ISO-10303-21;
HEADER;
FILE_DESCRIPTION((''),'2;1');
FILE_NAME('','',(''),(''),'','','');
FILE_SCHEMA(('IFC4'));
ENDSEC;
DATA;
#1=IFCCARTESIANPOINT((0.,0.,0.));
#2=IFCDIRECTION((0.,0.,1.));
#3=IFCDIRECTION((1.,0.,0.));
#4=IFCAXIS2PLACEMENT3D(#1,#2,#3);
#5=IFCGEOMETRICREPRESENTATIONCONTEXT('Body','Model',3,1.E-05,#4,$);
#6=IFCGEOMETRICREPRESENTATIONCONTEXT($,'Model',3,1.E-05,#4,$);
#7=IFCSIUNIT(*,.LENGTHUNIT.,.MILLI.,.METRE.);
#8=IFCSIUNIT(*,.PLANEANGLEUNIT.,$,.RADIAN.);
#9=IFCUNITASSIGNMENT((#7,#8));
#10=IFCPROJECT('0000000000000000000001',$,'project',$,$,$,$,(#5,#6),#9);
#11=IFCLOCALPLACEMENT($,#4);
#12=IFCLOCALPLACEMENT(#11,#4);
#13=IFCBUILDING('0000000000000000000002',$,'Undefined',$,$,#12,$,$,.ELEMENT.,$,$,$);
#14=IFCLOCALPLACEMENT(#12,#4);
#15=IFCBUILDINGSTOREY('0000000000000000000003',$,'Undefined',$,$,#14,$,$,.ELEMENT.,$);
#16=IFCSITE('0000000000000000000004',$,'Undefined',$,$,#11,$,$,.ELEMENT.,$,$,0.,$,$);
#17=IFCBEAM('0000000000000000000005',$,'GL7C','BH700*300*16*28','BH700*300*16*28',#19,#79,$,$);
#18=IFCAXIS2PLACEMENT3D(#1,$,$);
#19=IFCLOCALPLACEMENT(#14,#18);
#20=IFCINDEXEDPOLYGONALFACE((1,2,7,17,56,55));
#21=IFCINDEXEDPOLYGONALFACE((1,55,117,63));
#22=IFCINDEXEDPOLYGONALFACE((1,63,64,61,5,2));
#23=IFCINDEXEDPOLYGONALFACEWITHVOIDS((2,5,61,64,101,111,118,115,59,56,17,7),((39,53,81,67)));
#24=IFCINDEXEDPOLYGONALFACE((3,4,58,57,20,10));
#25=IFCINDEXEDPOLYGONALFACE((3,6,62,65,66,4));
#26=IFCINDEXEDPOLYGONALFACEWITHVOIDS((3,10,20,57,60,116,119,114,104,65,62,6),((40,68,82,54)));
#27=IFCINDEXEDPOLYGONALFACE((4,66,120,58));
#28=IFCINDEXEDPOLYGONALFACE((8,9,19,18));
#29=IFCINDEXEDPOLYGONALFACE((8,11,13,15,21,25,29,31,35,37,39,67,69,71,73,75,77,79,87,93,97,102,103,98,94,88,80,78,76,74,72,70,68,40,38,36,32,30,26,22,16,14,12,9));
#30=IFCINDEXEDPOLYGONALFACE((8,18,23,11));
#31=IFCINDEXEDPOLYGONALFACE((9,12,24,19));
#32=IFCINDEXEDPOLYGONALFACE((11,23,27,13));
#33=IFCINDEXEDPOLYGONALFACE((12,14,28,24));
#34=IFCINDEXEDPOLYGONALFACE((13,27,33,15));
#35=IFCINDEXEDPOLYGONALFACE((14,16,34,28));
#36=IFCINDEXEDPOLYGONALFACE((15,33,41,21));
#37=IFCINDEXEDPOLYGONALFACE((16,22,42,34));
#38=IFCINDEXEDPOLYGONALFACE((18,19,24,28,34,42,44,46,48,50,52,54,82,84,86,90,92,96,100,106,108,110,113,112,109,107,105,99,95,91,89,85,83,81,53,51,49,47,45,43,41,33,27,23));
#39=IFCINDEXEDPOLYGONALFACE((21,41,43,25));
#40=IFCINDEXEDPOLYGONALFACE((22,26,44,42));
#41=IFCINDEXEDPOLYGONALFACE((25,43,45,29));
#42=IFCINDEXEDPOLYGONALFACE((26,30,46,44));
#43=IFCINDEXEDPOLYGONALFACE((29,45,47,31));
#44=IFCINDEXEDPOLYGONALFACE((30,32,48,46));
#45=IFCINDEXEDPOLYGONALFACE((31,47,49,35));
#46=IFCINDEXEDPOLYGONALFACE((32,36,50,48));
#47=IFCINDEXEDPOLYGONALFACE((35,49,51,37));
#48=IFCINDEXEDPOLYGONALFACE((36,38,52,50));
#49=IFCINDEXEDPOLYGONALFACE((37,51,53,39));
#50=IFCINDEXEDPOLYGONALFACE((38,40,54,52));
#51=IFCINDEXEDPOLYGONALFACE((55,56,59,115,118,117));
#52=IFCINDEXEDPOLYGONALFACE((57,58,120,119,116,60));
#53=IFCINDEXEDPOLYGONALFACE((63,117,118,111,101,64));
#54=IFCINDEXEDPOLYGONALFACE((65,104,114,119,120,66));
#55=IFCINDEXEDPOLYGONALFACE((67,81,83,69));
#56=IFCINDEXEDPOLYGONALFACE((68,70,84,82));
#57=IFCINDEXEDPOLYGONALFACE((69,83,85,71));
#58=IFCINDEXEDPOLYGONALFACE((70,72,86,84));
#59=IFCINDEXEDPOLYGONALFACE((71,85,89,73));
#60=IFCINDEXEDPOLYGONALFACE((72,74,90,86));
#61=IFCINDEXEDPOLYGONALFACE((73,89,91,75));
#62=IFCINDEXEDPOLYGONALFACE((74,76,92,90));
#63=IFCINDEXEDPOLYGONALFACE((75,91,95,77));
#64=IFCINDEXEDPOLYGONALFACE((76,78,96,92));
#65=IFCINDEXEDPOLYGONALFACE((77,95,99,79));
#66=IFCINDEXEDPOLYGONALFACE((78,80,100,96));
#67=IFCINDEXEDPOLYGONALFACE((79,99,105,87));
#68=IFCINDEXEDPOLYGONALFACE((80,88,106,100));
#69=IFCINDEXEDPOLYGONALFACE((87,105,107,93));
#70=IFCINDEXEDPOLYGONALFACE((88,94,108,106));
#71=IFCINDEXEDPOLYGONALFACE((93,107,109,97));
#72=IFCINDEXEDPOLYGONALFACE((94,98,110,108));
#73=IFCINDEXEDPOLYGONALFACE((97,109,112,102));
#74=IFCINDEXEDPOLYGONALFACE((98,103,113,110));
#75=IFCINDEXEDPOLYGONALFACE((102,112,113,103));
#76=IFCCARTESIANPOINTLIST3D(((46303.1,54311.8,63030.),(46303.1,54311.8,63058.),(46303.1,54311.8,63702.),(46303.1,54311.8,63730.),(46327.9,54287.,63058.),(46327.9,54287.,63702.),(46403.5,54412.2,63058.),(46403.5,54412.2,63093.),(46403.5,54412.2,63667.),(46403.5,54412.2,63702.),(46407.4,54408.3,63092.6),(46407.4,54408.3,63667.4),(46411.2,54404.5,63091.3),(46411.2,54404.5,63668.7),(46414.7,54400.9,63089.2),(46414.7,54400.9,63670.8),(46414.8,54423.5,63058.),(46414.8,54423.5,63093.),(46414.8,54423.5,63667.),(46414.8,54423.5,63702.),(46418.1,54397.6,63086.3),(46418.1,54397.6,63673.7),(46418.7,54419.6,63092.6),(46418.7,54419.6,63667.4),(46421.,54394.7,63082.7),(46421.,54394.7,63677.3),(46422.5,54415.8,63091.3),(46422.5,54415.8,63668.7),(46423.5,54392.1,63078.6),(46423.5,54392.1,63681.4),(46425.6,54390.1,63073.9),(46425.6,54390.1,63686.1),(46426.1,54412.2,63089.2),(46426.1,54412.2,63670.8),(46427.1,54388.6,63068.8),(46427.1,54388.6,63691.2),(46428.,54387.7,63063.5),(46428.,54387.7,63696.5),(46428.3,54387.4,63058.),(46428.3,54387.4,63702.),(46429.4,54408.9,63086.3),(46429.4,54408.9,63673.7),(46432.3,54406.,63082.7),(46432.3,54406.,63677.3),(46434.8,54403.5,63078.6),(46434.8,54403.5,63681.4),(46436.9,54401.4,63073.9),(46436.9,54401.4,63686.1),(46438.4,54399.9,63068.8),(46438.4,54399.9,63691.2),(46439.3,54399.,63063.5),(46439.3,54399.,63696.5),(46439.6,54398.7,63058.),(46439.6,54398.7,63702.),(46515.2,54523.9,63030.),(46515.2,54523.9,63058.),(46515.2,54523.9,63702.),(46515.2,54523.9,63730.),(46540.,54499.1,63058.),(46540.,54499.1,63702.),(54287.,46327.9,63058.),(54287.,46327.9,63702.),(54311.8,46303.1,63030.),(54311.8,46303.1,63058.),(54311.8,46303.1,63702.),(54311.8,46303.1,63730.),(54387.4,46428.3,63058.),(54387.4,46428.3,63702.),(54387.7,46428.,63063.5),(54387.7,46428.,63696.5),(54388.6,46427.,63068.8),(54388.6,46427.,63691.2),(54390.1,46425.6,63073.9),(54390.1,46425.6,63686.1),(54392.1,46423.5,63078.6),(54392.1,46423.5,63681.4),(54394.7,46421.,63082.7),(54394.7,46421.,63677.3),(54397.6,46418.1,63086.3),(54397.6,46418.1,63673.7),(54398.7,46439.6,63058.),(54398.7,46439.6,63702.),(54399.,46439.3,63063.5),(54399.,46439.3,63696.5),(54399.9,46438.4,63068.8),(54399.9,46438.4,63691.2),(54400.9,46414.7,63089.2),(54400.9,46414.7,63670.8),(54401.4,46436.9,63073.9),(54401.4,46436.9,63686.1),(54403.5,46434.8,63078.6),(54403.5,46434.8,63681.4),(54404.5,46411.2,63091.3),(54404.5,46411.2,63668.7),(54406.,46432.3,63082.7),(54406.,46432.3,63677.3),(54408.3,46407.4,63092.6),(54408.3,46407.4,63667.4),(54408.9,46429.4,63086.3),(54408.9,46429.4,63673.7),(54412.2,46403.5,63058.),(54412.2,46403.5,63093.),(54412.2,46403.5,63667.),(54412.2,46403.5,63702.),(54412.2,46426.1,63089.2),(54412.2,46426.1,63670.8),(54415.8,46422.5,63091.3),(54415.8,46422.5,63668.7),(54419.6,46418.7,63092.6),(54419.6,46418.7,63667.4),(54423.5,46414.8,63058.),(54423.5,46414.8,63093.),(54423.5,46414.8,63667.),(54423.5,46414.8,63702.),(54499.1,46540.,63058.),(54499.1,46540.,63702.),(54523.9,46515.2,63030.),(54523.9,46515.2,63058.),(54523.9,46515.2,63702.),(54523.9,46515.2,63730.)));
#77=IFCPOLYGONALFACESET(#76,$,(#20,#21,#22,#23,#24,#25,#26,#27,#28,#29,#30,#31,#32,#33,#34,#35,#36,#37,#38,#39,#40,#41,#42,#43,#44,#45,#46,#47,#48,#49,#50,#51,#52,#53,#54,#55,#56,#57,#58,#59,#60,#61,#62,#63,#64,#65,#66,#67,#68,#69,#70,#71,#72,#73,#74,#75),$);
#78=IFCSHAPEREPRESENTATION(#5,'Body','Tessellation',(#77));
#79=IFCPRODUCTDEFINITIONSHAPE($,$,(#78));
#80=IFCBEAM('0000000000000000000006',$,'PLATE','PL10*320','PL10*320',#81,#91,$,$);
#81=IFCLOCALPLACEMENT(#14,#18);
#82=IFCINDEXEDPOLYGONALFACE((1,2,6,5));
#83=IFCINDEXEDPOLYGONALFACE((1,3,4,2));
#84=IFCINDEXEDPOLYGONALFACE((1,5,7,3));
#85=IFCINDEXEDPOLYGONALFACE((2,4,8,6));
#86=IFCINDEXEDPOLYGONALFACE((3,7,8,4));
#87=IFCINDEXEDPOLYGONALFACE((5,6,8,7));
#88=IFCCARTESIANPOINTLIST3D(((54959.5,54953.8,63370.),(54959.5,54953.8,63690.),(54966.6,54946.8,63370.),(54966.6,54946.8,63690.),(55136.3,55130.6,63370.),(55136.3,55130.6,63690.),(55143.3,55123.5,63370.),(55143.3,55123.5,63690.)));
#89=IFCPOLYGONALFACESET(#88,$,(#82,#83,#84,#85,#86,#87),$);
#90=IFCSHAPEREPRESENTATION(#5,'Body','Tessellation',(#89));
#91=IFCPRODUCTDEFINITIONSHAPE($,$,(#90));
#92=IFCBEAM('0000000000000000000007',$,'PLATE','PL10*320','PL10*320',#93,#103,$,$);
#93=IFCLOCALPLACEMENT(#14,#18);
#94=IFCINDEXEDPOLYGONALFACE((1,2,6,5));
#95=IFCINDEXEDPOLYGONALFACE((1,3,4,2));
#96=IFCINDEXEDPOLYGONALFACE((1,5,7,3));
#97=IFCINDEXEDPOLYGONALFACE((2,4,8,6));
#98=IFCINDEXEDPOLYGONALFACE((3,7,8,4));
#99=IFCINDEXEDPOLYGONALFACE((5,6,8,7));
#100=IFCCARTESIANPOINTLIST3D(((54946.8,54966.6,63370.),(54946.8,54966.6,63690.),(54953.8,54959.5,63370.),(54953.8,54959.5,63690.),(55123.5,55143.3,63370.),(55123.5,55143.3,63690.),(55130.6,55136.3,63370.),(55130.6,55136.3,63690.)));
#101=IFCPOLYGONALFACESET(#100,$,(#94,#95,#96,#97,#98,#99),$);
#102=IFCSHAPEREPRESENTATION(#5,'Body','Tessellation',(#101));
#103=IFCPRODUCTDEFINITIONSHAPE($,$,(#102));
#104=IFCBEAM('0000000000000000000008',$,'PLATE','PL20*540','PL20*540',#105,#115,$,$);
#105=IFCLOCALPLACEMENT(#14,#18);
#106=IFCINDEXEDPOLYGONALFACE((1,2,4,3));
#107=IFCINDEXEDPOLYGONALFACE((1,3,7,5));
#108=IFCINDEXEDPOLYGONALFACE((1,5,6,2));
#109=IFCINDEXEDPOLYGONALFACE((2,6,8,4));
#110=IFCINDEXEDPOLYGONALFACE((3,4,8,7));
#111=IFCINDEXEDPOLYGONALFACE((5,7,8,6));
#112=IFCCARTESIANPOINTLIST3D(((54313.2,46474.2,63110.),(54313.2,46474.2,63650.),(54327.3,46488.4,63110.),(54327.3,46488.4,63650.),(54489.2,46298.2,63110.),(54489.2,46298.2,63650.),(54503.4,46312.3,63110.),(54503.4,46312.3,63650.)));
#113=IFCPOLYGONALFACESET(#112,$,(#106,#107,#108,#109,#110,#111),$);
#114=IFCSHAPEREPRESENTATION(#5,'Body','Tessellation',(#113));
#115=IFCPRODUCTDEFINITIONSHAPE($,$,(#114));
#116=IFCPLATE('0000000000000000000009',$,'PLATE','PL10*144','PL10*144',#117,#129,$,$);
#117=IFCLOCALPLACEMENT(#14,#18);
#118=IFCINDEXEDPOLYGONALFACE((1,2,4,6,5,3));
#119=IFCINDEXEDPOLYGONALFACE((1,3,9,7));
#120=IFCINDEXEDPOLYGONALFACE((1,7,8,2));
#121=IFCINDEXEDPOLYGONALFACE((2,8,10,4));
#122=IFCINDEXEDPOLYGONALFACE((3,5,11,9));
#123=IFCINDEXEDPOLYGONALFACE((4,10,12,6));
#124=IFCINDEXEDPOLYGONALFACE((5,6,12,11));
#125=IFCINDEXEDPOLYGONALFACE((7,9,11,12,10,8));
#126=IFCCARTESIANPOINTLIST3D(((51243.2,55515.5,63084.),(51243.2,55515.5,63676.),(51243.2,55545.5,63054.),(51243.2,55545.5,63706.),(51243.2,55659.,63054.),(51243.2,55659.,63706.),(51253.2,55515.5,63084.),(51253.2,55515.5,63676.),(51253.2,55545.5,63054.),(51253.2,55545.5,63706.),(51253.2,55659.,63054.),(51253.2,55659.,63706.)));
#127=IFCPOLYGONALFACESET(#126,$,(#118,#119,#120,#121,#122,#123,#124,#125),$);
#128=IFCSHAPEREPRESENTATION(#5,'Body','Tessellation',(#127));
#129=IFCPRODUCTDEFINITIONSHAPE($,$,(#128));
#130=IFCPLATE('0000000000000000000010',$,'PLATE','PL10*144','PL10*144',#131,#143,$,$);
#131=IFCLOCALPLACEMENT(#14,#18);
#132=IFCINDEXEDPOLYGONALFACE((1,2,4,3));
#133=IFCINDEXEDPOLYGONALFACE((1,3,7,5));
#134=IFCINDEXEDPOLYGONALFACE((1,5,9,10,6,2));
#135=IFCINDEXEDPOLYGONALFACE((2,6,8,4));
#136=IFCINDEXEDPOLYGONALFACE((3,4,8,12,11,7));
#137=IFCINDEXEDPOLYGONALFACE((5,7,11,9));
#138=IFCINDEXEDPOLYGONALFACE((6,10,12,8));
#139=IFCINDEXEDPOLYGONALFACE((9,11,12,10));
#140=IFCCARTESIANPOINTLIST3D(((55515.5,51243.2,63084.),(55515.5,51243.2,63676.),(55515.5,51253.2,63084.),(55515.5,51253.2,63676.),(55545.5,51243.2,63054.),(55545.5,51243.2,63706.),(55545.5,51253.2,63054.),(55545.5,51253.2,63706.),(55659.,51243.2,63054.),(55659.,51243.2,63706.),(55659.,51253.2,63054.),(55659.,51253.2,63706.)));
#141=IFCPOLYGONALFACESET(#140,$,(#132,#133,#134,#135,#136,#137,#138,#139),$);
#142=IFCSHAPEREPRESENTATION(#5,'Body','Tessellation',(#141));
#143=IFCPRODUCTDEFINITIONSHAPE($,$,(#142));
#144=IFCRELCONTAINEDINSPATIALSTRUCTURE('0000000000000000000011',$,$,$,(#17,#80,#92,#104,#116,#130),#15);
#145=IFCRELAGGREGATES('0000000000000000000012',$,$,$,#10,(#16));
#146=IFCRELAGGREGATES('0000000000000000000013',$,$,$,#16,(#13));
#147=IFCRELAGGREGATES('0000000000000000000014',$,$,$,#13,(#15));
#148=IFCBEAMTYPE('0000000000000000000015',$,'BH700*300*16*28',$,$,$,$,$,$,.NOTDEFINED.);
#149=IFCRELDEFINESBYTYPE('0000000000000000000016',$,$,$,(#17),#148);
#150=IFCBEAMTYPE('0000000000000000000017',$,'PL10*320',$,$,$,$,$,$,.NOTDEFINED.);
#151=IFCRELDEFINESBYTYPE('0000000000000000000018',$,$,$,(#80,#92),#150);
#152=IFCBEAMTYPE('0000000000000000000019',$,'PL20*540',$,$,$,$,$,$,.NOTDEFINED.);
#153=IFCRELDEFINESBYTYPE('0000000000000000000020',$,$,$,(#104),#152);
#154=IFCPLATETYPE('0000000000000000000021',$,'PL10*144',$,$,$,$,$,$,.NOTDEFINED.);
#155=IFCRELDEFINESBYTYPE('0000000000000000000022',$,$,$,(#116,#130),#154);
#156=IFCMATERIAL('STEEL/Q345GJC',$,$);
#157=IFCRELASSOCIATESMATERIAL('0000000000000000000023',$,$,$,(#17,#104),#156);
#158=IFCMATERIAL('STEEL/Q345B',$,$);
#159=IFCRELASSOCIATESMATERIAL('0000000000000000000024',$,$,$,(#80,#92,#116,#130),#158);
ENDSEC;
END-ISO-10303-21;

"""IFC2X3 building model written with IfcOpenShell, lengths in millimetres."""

from ifc_helpers import new_model, si_unit, frame, origin_with_axes, origin_2d_with_axis, place, context, project, spatial, polyline, rectangle, i_section, outline, extrude, material, type_object, element, save


model = new_model("IFC2X3")

# Units and contexts
model_context_1 = context("Model", 3, precision=1e-05, world=origin_with_axes(), identifier="Body")
model_context_2 = context("Model", 3, precision=1e-05, world=origin_with_axes())
ifc_project = project(units=[si_unit("LENGTHUNIT", "METRE", prefix="MILLI"), si_unit("PLANEANGLEUNIT", "RADIAN")], contexts=[model_context_1, model_context_2])

# Site, building, storey
site_placement = place(None, origin_with_axes())
site = spatial("IfcSite", under=ifc_project, at=site_placement, Name="Undefined", CompositionType="ELEMENT", RefElevation=0.0)
building_placement = place(site_placement, origin_with_axes())
building = spatial("IfcBuilding", under=site, at=building_placement, Name="Undefined", CompositionType="ELEMENT")
storey_placement = place(building_placement, origin_with_axes())
storey = spatial("IfcBuildingStorey", under=building, at=storey_placement, Name="Undefined", CompositionType="ELEMENT")

# Shared definitions
ifc_material_1 = material(Name="STEEL/Q345B")

# Beam, openings
ifc_material_2 = material(Name="STEEL/Q345GJC")
beam_type_1 = type_object("IfcBeamType", Name="BH700*300*16*28", PredefinedType="NOTDEFINED")
beam_1_placement = place(storey_placement, frame((55367.7, 45459.3, 63380.0), z_axis=(0.0, 0.0, 1.0), x_axis=(-0.707107, 0.707107, 0.0)))
beam_1 = element("IfcBeam", 1, at=beam_1_placement, inside=storey, type_object=beam_type_1, material=ifc_material_2, Name="GL7C", Description="BH700*300*16*28", ObjectType="BH700*300*16*28", context=model_context_1, shape_type="SweptSolid", body=[
    extrude(i_section(OverallWidth=300.0, OverallDepth=700.0, WebThickness=16.0, FlangeThickness=28.0, at=origin_2d_with_axis()), frame((12669.3, 0.0, 0.0), z_axis=(-1.0, 0.0, 0.0), x_axis=(0.0, -1.0, 0.0)), (0.0, 0.0, 1.0), 11325.9),
])
opening_1_placement = place(storey_placement, frame((55367.7, 45459.3, 63380.0), z_axis=(0.0, 0.0, 1.0), x_axis=(-0.707107, 0.707107, 0.0)))
element("IfcOpeningElement", 2, at=opening_1_placement, cuts=beam_1, ObjectType="Recess", context=model_context_1, shape_type="SweptSolid", body=[
    extrude(outline(polyline([(0.0, 0.0), (37.0, 0.0), (37.0, 35.0), (35.0, 35.0), (29.5, 34.6), (24.2, 33.3), (19.1, 31.2), (14.4, 28.3), (10.3, 24.7), (6.7, 20.6), (3.8, 15.9), (1.7, 10.8), (0.4, 5.5), (0.0, 0.0), (0.0, 0.0)])), frame((12634.3, -150.0, 322.0), z_axis=(0.0, 1.0, 0.0), x_axis=(1.0, 0.0, 0.0)), (0.0, 0.0, 1.0), 300.0),
])
opening_2_placement = place(storey_placement, frame((55367.7, 45459.3, 63380.0), z_axis=(0.0, 0.0, 1.0), x_axis=(-0.707107, 0.707107, 0.0)))
element("IfcOpeningElement", 3, at=opening_2_placement, cuts=beam_1, ObjectType="Recess", context=model_context_1, shape_type="SweptSolid", body=[
    extrude(outline(polyline([(0.0, 0.0), (37.0, 0.0), (36.6, 5.5), (35.3, 10.8), (33.2, 15.9), (30.3, 20.6), (26.7, 24.7), (22.6, 28.3), (17.9, 31.2), (12.8, 33.3), (7.5, 34.6), (2.0, 35.0), (0.0, 35.0), (0.0, 0.0)])), frame((12671.3, -150.0, -322.0), z_axis=(0.0, 1.0, 0.0), x_axis=(-1.0, 0.0, 0.0)), (0.0, 0.0, 1.0), 300.0),
])
opening_3_placement = place(storey_placement, frame((55367.7, 45459.3, 63380.0), z_axis=(0.0, 0.0, 1.0), x_axis=(-0.707107, 0.707107, 0.0)))
element("IfcOpeningElement", 4, at=opening_3_placement, cuts=beam_1, ObjectType="Recess", context=model_context_1, shape_type="SweptSolid", body=[
    extrude(outline(polyline([(0.0, 0.0), (37.0, 0.0), (37.0, 35.0), (35.0, 35.0), (29.5, 34.6), (24.2, 33.3), (19.1, 31.2), (14.4, 28.3), (10.3, 24.7), (6.7, 20.6), (3.8, 15.9), (1.7, 10.8), (0.4, 5.5), (0.0, 0.0), (0.0, 0.0)])), frame((1378.4, 150.0, 322.0), z_axis=(0.0, -1.0, 0.0), x_axis=(-1.0, 0.0, 0.0)), (0.0, 0.0, 1.0), 300.0),
])
opening_4_placement = place(storey_placement, frame((55367.7, 45459.3, 63380.0), z_axis=(0.0, 0.0, 1.0), x_axis=(-0.707107, 0.707107, 0.0)))
element("IfcOpeningElement", 5, at=opening_4_placement, cuts=beam_1, ObjectType="Recess", context=model_context_1, shape_type="SweptSolid", body=[
    extrude(outline(polyline([(0.0, 0.0), (37.0, 0.0), (36.6, 5.5), (35.3, 10.8), (33.2, 15.9), (30.3, 20.6), (26.7, 24.7), (22.6, 28.3), (17.9, 31.2), (12.8, 33.3), (7.5, 34.6), (2.0, 35.0), (0.0, 35.0), (0.0, 0.0)])), frame((1341.4, 150.0, -322.0), z_axis=(0.0, -1.0, 0.0), x_axis=(1.0, 0.0, 0.0)), (0.0, 0.0, 1.0), 300.0),
])
opening_5_placement = place(storey_placement, frame((55367.7, 45459.3, 63380.0), z_axis=(0.0, 0.0, 1.0), x_axis=(-0.707107, 0.707107, 0.0)))
element("IfcOpeningElement", 6, at=opening_5_placement, cuts=beam_1, ObjectType="Recess", context=model_context_1, shape_type="SweptSolid", body=[
    extrude(outline(polyline([(0.0, 0.0), (37.0, 0.0), (37.0, 35.0), (35.0, 35.0), (29.5, 34.6), (24.2, 33.3), (19.1, 31.2), (14.4, 28.3), (10.3, 24.7), (6.7, 20.6), (3.8, 15.9), (1.7, 10.8), (0.4, 5.5), (0.0, 0.0), (0.0, 0.0)])), frame((1378.4, 150.0, 322.0), z_axis=(0.0, -1.0, 0.0), x_axis=(-1.0, 0.0, 0.0)), (0.0, 0.0, 1.0), 300.0),
])
opening_6_placement = place(storey_placement, frame((55367.7, 45459.3, 63380.0), z_axis=(0.0, 0.0, 1.0), x_axis=(-0.707107, 0.707107, 0.0)))
element("IfcOpeningElement", 7, at=opening_6_placement, cuts=beam_1, ObjectType="Recess", context=model_context_1, shape_type="SweptSolid", body=[
    extrude(outline(polyline([(0.0, 0.0), (37.0, 0.0), (36.6, 5.5), (35.3, 10.8), (33.2, 15.9), (30.3, 20.6), (26.7, 24.7), (22.6, 28.3), (17.9, 31.2), (12.8, 33.3), (7.5, 34.6), (2.0, 35.0), (0.0, 35.0), (0.0, 0.0)])), frame((1341.4, 150.0, -322.0), z_axis=(0.0, -1.0, 0.0), x_axis=(1.0, 0.0, 0.0)), (0.0, 0.0, 1.0), 300.0),
])

# Beams
beam_type_2 = type_object("IfcBeamType", Name="PL10*320", PredefinedType="NOTDEFINED")
for number, where, z_axis, x_axis, name in (
    (8, (55139.8, 55127.1, 63530.0), (0.0, 0.0, 1.0), (-0.707107, -0.707107, 0.0), "PLATE"),
    (9, (55127.1, 55139.8, 63530.0), (0.0, 0.0, 1.0), (-0.707107, -0.707107, 0.0), "PLATE"),
):
    element("IfcBeam", number, at=place(storey_placement, frame(where, z_axis=z_axis, x_axis=x_axis)), inside=storey, type_object=beam_type_2, material=ifc_material_1, Name=name, Description="PL10*320", ObjectType="PL10*320", context=model_context_1, shape_type="SweptSolid", body=[
        extrude(rectangle(XDim=10.0, YDim=320.0, at=origin_2d_with_axis()), frame((250.0, 0.0, 0.0), z_axis=(-1.0, 0.0, 0.0), x_axis=(0.0, -1.0, 0.0)), (0.0, 0.0, 1.0), 250.0),
    ])
beam_type_3 = type_object("IfcBeamType", Name="PL20*540", PredefinedType="NOTDEFINED")
beam_2_placement = place(storey_placement, frame((54496.3, 46305.2, 63380.0), z_axis=(0.0, 0.0, 1.0), x_axis=(-0.707107, 0.707107, 0.0)))
element("IfcBeam", 10, at=beam_2_placement, inside=storey, type_object=beam_type_3, material=ifc_material_2, Name="PLATE", Description="PL20*540", ObjectType="PL20*540", context=model_context_1, shape_type="SweptSolid", body=[
    extrude(rectangle(XDim=20.0, YDim=540.0, at=origin_2d_with_axis()), frame((249.0, 0.0, 0.0), z_axis=(-1.0, 0.0, 0.0), x_axis=(0.0, -1.0, 0.0)), (0.0, 0.0, 1.0), 249.0),
])

# Plates
plate_type_1 = type_object("IfcPlateType", Name="PL10*144", PredefinedType="NOTDEFINED")
for number, where, z_axis, x_axis, name in (
    (11, (51248.2, 55515.5, 63054.0), (1.0, 0.0, 0.0), (0.0, 1.0, 0.0), "PLATE"),
    (12, (55515.5, 51248.2, 63054.0), (0.0, -1.0, 0.0), (1.0, 0.0, 0.0), "PLATE"),
):
    element("IfcPlate", number, at=place(storey_placement, frame(where, z_axis=z_axis, x_axis=x_axis)), inside=storey, type_object=plate_type_1, material=ifc_material_1, Name=name, Description="PL10*144", ObjectType="PL10*144", context=model_context_1, shape_type="SweptSolid", body=[
        extrude(outline(polyline([(0.0, 30.0), (30.0, 0.0), (143.5, 0.0), (143.5, 652.0), (30.0, 652.0), (0.0, 622.0), (0.0, 30.0)])), frame((0.0, 0.0, -5.0), z_axis=(0.0, 0.0, 1.0), x_axis=(1.0, 0.0, 0.0)), (0.0, 0.0, 1.0), 10.0),
    ])

save(model, "model.ifc")
